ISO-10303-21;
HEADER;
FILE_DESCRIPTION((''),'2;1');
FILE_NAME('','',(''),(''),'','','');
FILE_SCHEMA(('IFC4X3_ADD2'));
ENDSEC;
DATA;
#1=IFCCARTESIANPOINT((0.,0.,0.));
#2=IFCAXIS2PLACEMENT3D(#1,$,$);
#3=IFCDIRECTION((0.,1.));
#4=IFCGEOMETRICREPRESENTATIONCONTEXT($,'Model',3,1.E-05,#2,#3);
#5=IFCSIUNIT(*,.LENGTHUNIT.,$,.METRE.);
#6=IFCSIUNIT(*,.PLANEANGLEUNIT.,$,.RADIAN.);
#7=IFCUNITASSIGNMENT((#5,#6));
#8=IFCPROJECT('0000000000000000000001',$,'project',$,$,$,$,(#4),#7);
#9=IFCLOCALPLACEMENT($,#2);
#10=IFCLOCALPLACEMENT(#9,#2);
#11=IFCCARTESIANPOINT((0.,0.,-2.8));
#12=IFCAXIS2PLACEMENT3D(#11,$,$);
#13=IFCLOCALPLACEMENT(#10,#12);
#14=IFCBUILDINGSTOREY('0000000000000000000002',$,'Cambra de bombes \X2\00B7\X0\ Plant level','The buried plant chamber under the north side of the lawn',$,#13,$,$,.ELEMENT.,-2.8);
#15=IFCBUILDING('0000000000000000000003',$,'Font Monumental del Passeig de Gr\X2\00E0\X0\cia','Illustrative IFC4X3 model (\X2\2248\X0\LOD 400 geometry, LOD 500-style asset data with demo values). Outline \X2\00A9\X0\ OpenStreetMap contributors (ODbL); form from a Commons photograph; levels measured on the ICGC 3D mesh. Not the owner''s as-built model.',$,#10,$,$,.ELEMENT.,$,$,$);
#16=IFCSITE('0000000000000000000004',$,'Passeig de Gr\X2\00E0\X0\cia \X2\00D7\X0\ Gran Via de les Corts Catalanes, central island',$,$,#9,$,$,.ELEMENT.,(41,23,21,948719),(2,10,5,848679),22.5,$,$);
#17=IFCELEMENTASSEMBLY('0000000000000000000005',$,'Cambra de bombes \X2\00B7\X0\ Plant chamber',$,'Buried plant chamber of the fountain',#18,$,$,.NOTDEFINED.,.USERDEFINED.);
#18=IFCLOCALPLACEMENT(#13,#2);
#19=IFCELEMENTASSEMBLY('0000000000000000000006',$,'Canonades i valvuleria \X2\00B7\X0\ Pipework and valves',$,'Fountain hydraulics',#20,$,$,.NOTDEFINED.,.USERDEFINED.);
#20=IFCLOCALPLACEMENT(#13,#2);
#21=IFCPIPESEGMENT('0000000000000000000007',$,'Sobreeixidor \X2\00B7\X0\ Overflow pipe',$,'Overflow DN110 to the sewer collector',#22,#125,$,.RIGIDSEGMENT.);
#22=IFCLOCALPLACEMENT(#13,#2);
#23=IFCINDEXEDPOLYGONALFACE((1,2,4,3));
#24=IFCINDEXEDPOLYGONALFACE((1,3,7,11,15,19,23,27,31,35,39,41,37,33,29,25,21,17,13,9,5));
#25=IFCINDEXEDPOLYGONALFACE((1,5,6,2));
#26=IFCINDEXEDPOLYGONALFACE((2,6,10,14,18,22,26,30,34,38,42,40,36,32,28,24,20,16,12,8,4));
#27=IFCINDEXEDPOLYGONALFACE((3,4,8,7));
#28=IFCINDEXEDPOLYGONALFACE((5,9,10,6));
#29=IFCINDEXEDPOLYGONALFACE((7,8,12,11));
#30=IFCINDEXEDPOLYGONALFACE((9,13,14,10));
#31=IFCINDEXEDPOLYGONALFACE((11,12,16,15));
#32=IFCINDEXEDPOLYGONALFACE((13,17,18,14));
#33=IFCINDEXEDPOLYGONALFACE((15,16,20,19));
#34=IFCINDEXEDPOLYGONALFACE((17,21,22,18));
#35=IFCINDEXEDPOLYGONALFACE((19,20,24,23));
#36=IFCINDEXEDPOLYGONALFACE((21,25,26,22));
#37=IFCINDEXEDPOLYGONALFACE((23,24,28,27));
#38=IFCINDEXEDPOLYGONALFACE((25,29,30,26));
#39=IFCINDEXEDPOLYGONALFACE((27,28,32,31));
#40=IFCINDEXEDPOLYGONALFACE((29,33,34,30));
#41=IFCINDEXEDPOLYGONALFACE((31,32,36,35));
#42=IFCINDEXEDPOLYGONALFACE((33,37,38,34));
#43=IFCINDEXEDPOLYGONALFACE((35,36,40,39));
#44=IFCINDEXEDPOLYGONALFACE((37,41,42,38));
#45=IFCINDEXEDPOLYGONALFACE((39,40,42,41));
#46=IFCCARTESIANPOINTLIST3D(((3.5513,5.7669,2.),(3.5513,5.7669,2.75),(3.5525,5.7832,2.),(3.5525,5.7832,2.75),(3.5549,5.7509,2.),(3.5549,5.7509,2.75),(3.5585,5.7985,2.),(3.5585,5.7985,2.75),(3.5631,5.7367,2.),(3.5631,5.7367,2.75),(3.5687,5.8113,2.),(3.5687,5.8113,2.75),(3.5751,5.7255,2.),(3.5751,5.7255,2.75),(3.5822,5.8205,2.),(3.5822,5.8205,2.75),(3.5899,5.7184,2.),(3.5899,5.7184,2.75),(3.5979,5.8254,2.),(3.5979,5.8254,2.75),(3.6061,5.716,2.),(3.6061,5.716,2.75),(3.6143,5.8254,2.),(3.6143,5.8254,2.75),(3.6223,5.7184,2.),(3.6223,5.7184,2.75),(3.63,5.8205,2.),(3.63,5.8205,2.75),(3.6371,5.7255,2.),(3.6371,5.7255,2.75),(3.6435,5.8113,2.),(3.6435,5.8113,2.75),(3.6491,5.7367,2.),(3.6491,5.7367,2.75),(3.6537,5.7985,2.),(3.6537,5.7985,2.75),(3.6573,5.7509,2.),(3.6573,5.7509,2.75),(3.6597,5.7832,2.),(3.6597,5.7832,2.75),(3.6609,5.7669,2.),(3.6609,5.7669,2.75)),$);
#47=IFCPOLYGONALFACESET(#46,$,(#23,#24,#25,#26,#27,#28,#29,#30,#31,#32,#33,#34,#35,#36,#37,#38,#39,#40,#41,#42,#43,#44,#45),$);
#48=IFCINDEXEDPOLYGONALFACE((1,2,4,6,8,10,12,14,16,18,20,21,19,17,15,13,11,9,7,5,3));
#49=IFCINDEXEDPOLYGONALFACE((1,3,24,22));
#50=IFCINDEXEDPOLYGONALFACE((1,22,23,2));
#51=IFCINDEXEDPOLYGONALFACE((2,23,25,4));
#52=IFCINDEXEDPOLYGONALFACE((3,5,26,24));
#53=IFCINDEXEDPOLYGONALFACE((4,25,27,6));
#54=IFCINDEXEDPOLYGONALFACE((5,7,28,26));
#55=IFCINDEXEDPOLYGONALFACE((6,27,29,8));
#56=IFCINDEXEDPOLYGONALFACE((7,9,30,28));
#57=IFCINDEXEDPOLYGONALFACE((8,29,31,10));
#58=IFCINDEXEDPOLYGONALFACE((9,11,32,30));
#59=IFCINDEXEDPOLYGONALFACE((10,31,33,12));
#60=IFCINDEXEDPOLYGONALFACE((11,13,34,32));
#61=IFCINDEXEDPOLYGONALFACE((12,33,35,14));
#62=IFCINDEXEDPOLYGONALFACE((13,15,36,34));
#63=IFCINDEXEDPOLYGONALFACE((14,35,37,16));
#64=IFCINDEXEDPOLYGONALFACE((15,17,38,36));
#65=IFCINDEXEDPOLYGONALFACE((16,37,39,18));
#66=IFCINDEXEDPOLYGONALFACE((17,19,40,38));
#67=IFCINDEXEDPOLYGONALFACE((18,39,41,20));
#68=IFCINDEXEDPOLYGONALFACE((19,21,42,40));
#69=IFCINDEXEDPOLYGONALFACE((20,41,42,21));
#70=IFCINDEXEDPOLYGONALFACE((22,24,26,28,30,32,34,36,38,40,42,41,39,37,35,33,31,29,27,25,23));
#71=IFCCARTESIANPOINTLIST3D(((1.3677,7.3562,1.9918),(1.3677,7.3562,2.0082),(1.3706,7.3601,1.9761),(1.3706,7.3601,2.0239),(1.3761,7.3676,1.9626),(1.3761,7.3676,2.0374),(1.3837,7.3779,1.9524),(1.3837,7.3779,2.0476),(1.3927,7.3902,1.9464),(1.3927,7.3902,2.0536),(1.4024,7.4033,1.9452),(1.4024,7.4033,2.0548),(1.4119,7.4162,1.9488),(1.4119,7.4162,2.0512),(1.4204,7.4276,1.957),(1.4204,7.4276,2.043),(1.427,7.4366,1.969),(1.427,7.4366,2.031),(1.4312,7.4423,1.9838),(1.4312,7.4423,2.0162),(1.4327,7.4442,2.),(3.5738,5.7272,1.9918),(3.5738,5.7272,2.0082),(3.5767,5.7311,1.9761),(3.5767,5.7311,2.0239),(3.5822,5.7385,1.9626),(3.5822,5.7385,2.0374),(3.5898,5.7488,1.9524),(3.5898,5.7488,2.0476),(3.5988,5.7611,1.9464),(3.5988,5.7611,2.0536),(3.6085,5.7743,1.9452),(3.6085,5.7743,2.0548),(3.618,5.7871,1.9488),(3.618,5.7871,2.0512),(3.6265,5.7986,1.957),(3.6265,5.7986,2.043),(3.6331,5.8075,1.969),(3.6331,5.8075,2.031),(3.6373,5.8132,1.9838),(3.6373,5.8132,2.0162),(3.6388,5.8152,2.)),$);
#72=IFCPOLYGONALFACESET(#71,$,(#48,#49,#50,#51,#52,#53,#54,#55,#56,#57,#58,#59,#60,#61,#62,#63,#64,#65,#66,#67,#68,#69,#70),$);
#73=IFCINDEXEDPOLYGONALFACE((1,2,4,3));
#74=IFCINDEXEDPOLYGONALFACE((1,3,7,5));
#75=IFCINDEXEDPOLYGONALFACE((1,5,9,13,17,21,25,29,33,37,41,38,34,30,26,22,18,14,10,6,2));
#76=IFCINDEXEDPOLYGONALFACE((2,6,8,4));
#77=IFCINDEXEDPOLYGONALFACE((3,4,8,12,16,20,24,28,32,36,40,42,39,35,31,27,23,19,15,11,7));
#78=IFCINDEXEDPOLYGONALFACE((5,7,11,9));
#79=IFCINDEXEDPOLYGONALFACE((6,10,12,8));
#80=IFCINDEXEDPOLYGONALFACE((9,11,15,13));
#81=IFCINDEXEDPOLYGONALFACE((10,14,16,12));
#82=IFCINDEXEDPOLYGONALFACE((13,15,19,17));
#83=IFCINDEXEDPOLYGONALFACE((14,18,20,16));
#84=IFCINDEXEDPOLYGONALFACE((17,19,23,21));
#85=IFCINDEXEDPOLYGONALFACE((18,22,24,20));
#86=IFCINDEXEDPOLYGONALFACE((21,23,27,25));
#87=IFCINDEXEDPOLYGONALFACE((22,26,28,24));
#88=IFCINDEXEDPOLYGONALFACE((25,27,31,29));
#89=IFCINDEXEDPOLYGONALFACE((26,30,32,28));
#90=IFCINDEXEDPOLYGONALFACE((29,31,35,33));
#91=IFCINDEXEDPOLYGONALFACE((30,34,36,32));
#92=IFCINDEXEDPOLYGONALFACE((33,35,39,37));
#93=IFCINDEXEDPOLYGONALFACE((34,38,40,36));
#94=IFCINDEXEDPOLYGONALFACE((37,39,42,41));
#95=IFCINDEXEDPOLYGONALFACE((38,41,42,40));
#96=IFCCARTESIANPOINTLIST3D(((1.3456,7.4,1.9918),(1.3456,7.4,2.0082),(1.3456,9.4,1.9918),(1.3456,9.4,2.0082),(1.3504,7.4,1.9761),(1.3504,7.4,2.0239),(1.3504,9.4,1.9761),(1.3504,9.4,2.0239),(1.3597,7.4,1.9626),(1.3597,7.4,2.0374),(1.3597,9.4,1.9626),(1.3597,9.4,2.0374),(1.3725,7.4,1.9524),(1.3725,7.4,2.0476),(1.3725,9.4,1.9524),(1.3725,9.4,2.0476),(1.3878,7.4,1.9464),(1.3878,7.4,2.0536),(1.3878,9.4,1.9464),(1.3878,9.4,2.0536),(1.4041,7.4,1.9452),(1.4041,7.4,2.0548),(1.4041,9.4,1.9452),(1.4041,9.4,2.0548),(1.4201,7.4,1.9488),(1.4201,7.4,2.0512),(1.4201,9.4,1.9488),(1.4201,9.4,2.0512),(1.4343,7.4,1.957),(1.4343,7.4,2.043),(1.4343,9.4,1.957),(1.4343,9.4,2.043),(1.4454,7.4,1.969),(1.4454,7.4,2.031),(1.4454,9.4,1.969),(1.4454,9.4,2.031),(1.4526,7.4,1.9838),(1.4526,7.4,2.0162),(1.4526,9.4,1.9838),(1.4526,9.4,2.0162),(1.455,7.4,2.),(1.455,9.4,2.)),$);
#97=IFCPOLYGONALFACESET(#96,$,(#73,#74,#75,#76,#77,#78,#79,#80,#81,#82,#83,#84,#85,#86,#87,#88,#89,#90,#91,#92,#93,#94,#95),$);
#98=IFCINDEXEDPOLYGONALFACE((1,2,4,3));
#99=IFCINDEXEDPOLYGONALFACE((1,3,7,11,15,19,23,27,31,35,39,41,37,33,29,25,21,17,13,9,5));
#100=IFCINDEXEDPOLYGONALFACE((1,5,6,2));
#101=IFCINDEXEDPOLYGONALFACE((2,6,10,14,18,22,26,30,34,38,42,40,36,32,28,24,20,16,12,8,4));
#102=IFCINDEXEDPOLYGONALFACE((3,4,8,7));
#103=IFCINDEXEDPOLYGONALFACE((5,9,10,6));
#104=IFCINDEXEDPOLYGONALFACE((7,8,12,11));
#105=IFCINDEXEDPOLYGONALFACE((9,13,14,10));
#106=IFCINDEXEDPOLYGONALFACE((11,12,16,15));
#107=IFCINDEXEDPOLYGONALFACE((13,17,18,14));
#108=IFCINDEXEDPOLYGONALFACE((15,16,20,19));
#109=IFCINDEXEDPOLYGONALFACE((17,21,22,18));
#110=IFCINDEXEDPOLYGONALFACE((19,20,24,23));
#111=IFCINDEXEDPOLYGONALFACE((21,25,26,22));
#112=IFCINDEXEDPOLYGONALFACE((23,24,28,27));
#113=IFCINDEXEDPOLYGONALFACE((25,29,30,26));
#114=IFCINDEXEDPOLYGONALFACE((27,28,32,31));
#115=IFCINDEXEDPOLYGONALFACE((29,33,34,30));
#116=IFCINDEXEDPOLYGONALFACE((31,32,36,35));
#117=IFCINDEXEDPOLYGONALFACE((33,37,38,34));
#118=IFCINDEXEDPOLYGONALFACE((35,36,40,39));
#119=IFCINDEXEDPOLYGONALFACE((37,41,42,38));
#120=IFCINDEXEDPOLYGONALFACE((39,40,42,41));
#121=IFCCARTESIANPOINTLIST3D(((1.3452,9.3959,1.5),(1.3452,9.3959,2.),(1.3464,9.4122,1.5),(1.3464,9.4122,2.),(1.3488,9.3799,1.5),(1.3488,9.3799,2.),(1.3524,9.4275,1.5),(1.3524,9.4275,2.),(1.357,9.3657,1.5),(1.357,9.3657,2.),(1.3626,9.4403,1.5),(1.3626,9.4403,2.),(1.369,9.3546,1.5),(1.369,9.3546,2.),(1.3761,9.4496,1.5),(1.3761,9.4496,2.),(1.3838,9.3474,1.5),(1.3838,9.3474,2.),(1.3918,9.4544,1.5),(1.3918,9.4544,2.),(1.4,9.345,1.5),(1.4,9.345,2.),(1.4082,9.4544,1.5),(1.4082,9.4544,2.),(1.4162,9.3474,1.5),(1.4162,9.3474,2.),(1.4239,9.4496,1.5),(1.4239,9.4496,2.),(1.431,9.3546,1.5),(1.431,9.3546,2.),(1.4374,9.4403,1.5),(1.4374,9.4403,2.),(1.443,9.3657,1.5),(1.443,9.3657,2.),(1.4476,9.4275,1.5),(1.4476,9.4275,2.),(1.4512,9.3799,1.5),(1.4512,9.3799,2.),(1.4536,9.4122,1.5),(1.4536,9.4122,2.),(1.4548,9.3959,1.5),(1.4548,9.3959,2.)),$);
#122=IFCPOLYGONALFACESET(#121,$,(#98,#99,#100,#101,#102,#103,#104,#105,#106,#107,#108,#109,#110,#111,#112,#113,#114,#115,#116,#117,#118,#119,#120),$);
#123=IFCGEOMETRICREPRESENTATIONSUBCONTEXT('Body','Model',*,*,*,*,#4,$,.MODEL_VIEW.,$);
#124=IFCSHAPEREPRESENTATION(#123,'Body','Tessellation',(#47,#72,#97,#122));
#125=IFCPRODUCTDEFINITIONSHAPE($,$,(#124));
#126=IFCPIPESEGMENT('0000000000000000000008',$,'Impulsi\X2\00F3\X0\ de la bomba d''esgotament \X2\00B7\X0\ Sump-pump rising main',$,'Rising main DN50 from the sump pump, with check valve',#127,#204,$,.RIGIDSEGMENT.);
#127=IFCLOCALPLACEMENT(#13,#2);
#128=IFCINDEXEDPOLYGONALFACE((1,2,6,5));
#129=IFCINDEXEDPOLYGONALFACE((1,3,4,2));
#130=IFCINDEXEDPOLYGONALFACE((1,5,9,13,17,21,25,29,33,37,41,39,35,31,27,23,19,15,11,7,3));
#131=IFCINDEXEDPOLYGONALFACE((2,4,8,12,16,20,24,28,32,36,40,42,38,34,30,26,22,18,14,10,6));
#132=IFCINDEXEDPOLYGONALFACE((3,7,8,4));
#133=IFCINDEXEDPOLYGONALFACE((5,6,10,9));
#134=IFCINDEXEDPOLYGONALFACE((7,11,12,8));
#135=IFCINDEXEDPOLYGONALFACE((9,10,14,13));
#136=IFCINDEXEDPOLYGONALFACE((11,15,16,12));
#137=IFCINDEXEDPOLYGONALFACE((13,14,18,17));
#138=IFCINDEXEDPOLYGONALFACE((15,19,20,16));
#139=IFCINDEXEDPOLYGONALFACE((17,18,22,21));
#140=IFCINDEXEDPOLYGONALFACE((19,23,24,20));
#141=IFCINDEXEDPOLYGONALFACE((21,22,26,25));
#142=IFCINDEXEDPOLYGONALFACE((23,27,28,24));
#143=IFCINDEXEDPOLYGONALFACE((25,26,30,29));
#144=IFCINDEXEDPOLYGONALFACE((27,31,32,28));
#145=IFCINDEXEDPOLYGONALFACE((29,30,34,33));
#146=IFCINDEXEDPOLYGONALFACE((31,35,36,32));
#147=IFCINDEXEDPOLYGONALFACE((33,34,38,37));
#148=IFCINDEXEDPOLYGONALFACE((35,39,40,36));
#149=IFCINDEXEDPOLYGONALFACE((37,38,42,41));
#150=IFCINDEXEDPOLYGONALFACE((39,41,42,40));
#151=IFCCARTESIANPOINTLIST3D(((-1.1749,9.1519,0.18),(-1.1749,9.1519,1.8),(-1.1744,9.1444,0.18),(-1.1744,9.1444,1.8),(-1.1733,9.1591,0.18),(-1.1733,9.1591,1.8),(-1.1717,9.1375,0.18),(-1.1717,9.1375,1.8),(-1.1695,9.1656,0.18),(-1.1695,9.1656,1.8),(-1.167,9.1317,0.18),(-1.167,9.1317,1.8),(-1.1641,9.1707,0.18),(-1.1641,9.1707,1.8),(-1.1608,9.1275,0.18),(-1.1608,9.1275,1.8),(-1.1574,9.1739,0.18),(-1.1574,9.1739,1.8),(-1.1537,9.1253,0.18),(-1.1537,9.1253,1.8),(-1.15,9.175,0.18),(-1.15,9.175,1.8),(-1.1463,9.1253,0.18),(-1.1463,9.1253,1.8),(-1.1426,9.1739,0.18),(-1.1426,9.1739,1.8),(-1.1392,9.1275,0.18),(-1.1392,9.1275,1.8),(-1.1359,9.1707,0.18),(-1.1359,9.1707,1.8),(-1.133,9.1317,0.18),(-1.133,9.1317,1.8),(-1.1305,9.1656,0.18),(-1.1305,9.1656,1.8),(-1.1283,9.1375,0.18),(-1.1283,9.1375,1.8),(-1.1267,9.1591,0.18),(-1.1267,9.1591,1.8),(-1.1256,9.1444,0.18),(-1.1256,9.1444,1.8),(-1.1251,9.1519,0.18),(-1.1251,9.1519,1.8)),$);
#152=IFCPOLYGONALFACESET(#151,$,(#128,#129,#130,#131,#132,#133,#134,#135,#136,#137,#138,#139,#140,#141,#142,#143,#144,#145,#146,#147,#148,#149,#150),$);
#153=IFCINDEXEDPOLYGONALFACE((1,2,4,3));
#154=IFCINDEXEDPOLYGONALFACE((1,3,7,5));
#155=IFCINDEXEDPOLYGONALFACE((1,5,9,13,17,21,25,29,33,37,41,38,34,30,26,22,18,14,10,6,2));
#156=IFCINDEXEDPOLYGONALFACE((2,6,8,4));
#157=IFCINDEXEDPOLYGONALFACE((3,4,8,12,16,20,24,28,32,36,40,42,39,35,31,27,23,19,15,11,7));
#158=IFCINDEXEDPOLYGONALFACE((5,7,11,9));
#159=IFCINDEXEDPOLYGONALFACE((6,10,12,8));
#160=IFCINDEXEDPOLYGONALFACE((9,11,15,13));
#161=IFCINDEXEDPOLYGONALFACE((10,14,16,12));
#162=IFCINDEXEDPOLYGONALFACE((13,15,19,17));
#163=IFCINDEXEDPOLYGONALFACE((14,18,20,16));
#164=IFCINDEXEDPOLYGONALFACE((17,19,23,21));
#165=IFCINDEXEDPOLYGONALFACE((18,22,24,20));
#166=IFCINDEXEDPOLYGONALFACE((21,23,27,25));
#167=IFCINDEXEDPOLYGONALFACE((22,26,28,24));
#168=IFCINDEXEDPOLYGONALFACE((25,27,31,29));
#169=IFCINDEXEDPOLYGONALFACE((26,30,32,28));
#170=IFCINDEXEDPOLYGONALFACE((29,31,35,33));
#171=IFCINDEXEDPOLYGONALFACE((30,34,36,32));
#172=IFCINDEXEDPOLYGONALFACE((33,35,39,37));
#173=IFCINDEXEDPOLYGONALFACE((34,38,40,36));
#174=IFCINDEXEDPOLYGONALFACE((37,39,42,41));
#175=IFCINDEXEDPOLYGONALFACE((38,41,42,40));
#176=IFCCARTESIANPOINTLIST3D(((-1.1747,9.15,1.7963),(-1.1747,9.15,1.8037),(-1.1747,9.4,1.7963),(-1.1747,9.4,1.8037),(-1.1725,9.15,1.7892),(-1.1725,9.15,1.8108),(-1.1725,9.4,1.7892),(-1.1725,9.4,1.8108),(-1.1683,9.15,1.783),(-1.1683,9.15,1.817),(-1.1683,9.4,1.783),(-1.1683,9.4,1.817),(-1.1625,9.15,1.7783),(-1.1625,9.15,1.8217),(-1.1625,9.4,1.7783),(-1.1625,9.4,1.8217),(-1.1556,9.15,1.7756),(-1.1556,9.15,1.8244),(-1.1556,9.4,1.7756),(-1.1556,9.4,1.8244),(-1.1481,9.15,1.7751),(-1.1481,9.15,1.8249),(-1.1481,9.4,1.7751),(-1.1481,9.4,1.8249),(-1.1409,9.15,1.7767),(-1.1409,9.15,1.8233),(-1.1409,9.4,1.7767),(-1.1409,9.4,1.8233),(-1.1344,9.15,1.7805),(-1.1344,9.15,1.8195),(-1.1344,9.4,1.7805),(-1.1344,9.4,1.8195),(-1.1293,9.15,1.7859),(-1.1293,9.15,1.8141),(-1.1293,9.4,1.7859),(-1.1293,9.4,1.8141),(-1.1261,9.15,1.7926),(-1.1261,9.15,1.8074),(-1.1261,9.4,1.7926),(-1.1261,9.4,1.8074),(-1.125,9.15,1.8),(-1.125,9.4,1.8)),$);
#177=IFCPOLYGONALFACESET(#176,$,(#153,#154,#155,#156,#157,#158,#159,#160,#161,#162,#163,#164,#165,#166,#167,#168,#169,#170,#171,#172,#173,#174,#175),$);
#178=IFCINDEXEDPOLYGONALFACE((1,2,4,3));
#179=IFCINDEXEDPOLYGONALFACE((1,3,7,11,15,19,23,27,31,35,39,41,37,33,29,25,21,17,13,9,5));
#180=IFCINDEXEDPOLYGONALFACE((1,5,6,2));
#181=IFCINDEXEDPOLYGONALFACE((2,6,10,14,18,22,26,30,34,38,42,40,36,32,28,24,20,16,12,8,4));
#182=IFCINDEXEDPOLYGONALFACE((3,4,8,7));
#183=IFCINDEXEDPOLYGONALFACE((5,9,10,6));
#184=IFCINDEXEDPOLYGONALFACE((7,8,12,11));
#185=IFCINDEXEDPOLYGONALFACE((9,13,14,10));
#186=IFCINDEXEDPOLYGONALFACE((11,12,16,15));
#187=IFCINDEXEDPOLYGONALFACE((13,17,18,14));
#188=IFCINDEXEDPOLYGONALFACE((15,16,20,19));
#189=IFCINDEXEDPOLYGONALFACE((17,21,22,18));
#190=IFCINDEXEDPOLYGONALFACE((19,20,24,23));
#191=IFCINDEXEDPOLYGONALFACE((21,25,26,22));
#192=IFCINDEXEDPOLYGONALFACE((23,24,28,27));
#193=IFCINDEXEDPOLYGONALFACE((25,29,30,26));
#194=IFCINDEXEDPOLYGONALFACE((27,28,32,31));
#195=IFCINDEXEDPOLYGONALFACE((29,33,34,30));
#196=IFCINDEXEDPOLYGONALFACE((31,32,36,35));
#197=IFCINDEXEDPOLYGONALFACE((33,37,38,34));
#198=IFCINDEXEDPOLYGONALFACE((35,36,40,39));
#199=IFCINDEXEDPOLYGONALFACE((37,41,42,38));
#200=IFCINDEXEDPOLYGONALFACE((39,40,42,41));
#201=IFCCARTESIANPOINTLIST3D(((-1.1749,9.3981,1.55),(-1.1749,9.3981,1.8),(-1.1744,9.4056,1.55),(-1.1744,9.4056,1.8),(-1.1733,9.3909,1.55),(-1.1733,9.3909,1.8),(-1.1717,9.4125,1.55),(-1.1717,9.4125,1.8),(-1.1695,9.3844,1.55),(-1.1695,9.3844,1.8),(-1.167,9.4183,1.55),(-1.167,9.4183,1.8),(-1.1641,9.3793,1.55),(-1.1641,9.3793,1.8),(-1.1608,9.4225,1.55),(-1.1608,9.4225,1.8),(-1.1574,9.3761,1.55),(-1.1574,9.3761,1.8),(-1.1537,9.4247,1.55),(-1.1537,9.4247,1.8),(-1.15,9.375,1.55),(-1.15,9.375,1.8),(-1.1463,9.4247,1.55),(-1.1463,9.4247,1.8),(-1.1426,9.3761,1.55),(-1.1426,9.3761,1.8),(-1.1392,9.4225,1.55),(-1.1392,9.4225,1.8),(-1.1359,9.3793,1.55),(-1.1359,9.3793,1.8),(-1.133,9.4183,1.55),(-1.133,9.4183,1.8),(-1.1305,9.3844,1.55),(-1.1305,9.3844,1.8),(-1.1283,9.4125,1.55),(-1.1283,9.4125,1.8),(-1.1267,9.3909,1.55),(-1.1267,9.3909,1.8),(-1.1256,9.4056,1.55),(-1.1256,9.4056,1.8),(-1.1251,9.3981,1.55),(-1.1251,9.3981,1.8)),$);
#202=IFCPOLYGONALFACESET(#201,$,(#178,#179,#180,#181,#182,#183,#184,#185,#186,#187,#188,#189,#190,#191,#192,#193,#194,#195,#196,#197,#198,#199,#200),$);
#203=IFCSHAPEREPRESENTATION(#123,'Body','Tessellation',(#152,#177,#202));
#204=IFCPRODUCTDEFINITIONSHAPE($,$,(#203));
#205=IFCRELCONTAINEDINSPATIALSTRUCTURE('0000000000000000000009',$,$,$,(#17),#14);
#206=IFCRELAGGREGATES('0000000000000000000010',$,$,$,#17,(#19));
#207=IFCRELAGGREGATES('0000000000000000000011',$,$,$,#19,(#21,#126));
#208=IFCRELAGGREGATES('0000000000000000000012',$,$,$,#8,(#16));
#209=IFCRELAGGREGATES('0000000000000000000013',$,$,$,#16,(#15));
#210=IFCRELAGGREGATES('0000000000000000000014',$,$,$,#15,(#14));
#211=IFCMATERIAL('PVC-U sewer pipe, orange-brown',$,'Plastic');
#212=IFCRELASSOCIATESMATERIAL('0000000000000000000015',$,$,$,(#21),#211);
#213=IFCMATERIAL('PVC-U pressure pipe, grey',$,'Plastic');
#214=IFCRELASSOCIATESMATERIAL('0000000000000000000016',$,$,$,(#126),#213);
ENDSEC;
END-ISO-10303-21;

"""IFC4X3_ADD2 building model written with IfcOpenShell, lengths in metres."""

from ifc_helpers import new_model, si_unit, direction, frame, origin, origin_2d_with_axis, place, context, subcontext, project, spatial, circle, extrude, material, element, aggregate, save


model = new_model("IFC4X3_ADD2")

# Units and contexts
model_context = context("Model", 3, precision=1e-05, world=origin(), true_north=direction((0.0, 1.0)))
body_context = subcontext(model_context, "Body", "Model", "MODEL_VIEW")
ifc_project = project(units=[si_unit("LENGTHUNIT", "METRE"), si_unit("PLANEANGLEUNIT", "RADIAN")], contexts=[model_context])

# Site, building, storey
site_placement = place(None, origin())
site = spatial("IfcSite", under=ifc_project, at=site_placement, Name="Passeig de Gràcia × Gran Via de les Corts Catalanes, central island", CompositionType="ELEMENT", RefLatitude=(41, 23, 21, 948719), RefLongitude=(2, 10, 5, 848679), RefElevation=22.5)
building_placement = place(site_placement, origin())
building = spatial("IfcBuilding", under=site, at=building_placement, Name="Font Monumental del Passeig de Gràcia", Description="Illustrative IFC4X3 model (≈LOD 400 geometry, LOD 500-style asset data with demo values). Outline © OpenStreetMap contributors (ODbL); form from a Commons photograph; levels measured on the ICGC 3D mesh. Not the owner's as-built model.", CompositionType="ELEMENT")
storey_placement = place(building_placement, frame((0.0, 0.0, -2.8)))
storey = spatial("IfcBuildingStorey", under=building, at=storey_placement, Name="Cambra de bombes · Plant level", Description="The buried plant chamber under the north side of the lawn", CompositionType="ELEMENT", Elevation=-2.8)

# Element assemblies, pipe segments
assembly_1_placement = place(building_placement, origin())
assembly_1 = element("IfcElementAssembly", 1, at=assembly_1_placement, inside=storey, Name="Cambra de bombes · Plant chamber", ObjectType="Buried plant chamber of the fountain", AssemblyPlace="NOTDEFINED", PredefinedType="USERDEFINED")
assembly_2_placement = place(building_placement, origin())
assembly_2 = element("IfcElementAssembly", 2, at=assembly_2_placement, Name="Canonades i valvuleria · Pipework and valves", ObjectType="Fountain hydraulics", AssemblyPlace="NOTDEFINED", PredefinedType="USERDEFINED")
aggregate(assembly_1, [assembly_2])
ifc_material_1 = material(Name="PVC-U pressure pipe, grey", Category="Plastic")
ifc_material_2 = material(Name="PVC-U sewer pipe, orange-brown", Category="Plastic")
pipe_segment_1_placement = place(building_placement, origin())
pipe_segment_1 = element("IfcPipeSegment", 3, at=pipe_segment_1_placement, material=ifc_material_2, Name="Sobreeixidor · Overflow pipe", ObjectType="Overflow DN110 to the sewer collector", PredefinedType="RIGIDSEGMENT", context=body_context, shape_type="SweptSolid", body=[
    extrude(circle(Radius=0.055, at=origin_2d_with_axis()), frame((3.6061, 5.771, -0.05), z_axis=(0.0, 0.0, -1.0), x_axis=(0.0, -1.0, 0.0)), (0.0, 0.0, 1.0), 0.75),
    extrude(circle(Radius=0.055, at=origin_2d_with_axis()), frame((3.6061, 5.771, -0.8), z_axis=(-0.804449, 0.594022, 0.0), x_axis=(0.594022, 0.804449, 0.0)), (0.0, 0.0, 1.0), 2.7424),
    extrude(circle(Radius=0.055, at=origin_2d_with_axis()), frame((1.4, 7.4, -0.8), z_axis=(0.0, 1.0, 0.0), x_axis=(1.0, 0.0, 0.0)), (0.0, 0.0, 1.0), 2.0),
    extrude(circle(Radius=0.055, at=origin_2d_with_axis()), frame((1.4, 9.4, -0.8), z_axis=(0.0, 0.0, -1.0), x_axis=(0.0, -1.0, 0.0)), (0.0, 0.0, 1.0), 0.5),
])
pipe_segment_2_placement = place(building_placement, origin())
pipe_segment_2 = element("IfcPipeSegment", 4, at=pipe_segment_2_placement, material=ifc_material_1, Name="Impulsió de la bomba d'esgotament · Sump-pump rising main", ObjectType="Rising main DN50 from the sump pump, with check valve", PredefinedType="RIGIDSEGMENT", context=body_context, shape_type="SweptSolid", body=[
    extrude(circle(Radius=0.025, at=origin_2d_with_axis()), frame((-1.15, 9.15, -2.62), z_axis=(0.0, 0.0, 1.0), x_axis=(0.0, 1.0, 0.0)), (0.0, 0.0, 1.0), 1.62),
    extrude(circle(Radius=0.025, at=origin_2d_with_axis()), frame((-1.15, 9.15, -1.0), z_axis=(0.0, 1.0, 0.0), x_axis=(1.0, 0.0, 0.0)), (0.0, 0.0, 1.0), 0.25),
    extrude(circle(Radius=0.025, at=origin_2d_with_axis()), frame((-1.15, 9.4, -1.0), z_axis=(0.0, 0.0, -1.0), x_axis=(0.0, -1.0, 0.0)), (0.0, 0.0, 1.0), 0.25),
])
aggregate(assembly_2, [pipe_segment_1, pipe_segment_2])

save(model, "model.ifc")
